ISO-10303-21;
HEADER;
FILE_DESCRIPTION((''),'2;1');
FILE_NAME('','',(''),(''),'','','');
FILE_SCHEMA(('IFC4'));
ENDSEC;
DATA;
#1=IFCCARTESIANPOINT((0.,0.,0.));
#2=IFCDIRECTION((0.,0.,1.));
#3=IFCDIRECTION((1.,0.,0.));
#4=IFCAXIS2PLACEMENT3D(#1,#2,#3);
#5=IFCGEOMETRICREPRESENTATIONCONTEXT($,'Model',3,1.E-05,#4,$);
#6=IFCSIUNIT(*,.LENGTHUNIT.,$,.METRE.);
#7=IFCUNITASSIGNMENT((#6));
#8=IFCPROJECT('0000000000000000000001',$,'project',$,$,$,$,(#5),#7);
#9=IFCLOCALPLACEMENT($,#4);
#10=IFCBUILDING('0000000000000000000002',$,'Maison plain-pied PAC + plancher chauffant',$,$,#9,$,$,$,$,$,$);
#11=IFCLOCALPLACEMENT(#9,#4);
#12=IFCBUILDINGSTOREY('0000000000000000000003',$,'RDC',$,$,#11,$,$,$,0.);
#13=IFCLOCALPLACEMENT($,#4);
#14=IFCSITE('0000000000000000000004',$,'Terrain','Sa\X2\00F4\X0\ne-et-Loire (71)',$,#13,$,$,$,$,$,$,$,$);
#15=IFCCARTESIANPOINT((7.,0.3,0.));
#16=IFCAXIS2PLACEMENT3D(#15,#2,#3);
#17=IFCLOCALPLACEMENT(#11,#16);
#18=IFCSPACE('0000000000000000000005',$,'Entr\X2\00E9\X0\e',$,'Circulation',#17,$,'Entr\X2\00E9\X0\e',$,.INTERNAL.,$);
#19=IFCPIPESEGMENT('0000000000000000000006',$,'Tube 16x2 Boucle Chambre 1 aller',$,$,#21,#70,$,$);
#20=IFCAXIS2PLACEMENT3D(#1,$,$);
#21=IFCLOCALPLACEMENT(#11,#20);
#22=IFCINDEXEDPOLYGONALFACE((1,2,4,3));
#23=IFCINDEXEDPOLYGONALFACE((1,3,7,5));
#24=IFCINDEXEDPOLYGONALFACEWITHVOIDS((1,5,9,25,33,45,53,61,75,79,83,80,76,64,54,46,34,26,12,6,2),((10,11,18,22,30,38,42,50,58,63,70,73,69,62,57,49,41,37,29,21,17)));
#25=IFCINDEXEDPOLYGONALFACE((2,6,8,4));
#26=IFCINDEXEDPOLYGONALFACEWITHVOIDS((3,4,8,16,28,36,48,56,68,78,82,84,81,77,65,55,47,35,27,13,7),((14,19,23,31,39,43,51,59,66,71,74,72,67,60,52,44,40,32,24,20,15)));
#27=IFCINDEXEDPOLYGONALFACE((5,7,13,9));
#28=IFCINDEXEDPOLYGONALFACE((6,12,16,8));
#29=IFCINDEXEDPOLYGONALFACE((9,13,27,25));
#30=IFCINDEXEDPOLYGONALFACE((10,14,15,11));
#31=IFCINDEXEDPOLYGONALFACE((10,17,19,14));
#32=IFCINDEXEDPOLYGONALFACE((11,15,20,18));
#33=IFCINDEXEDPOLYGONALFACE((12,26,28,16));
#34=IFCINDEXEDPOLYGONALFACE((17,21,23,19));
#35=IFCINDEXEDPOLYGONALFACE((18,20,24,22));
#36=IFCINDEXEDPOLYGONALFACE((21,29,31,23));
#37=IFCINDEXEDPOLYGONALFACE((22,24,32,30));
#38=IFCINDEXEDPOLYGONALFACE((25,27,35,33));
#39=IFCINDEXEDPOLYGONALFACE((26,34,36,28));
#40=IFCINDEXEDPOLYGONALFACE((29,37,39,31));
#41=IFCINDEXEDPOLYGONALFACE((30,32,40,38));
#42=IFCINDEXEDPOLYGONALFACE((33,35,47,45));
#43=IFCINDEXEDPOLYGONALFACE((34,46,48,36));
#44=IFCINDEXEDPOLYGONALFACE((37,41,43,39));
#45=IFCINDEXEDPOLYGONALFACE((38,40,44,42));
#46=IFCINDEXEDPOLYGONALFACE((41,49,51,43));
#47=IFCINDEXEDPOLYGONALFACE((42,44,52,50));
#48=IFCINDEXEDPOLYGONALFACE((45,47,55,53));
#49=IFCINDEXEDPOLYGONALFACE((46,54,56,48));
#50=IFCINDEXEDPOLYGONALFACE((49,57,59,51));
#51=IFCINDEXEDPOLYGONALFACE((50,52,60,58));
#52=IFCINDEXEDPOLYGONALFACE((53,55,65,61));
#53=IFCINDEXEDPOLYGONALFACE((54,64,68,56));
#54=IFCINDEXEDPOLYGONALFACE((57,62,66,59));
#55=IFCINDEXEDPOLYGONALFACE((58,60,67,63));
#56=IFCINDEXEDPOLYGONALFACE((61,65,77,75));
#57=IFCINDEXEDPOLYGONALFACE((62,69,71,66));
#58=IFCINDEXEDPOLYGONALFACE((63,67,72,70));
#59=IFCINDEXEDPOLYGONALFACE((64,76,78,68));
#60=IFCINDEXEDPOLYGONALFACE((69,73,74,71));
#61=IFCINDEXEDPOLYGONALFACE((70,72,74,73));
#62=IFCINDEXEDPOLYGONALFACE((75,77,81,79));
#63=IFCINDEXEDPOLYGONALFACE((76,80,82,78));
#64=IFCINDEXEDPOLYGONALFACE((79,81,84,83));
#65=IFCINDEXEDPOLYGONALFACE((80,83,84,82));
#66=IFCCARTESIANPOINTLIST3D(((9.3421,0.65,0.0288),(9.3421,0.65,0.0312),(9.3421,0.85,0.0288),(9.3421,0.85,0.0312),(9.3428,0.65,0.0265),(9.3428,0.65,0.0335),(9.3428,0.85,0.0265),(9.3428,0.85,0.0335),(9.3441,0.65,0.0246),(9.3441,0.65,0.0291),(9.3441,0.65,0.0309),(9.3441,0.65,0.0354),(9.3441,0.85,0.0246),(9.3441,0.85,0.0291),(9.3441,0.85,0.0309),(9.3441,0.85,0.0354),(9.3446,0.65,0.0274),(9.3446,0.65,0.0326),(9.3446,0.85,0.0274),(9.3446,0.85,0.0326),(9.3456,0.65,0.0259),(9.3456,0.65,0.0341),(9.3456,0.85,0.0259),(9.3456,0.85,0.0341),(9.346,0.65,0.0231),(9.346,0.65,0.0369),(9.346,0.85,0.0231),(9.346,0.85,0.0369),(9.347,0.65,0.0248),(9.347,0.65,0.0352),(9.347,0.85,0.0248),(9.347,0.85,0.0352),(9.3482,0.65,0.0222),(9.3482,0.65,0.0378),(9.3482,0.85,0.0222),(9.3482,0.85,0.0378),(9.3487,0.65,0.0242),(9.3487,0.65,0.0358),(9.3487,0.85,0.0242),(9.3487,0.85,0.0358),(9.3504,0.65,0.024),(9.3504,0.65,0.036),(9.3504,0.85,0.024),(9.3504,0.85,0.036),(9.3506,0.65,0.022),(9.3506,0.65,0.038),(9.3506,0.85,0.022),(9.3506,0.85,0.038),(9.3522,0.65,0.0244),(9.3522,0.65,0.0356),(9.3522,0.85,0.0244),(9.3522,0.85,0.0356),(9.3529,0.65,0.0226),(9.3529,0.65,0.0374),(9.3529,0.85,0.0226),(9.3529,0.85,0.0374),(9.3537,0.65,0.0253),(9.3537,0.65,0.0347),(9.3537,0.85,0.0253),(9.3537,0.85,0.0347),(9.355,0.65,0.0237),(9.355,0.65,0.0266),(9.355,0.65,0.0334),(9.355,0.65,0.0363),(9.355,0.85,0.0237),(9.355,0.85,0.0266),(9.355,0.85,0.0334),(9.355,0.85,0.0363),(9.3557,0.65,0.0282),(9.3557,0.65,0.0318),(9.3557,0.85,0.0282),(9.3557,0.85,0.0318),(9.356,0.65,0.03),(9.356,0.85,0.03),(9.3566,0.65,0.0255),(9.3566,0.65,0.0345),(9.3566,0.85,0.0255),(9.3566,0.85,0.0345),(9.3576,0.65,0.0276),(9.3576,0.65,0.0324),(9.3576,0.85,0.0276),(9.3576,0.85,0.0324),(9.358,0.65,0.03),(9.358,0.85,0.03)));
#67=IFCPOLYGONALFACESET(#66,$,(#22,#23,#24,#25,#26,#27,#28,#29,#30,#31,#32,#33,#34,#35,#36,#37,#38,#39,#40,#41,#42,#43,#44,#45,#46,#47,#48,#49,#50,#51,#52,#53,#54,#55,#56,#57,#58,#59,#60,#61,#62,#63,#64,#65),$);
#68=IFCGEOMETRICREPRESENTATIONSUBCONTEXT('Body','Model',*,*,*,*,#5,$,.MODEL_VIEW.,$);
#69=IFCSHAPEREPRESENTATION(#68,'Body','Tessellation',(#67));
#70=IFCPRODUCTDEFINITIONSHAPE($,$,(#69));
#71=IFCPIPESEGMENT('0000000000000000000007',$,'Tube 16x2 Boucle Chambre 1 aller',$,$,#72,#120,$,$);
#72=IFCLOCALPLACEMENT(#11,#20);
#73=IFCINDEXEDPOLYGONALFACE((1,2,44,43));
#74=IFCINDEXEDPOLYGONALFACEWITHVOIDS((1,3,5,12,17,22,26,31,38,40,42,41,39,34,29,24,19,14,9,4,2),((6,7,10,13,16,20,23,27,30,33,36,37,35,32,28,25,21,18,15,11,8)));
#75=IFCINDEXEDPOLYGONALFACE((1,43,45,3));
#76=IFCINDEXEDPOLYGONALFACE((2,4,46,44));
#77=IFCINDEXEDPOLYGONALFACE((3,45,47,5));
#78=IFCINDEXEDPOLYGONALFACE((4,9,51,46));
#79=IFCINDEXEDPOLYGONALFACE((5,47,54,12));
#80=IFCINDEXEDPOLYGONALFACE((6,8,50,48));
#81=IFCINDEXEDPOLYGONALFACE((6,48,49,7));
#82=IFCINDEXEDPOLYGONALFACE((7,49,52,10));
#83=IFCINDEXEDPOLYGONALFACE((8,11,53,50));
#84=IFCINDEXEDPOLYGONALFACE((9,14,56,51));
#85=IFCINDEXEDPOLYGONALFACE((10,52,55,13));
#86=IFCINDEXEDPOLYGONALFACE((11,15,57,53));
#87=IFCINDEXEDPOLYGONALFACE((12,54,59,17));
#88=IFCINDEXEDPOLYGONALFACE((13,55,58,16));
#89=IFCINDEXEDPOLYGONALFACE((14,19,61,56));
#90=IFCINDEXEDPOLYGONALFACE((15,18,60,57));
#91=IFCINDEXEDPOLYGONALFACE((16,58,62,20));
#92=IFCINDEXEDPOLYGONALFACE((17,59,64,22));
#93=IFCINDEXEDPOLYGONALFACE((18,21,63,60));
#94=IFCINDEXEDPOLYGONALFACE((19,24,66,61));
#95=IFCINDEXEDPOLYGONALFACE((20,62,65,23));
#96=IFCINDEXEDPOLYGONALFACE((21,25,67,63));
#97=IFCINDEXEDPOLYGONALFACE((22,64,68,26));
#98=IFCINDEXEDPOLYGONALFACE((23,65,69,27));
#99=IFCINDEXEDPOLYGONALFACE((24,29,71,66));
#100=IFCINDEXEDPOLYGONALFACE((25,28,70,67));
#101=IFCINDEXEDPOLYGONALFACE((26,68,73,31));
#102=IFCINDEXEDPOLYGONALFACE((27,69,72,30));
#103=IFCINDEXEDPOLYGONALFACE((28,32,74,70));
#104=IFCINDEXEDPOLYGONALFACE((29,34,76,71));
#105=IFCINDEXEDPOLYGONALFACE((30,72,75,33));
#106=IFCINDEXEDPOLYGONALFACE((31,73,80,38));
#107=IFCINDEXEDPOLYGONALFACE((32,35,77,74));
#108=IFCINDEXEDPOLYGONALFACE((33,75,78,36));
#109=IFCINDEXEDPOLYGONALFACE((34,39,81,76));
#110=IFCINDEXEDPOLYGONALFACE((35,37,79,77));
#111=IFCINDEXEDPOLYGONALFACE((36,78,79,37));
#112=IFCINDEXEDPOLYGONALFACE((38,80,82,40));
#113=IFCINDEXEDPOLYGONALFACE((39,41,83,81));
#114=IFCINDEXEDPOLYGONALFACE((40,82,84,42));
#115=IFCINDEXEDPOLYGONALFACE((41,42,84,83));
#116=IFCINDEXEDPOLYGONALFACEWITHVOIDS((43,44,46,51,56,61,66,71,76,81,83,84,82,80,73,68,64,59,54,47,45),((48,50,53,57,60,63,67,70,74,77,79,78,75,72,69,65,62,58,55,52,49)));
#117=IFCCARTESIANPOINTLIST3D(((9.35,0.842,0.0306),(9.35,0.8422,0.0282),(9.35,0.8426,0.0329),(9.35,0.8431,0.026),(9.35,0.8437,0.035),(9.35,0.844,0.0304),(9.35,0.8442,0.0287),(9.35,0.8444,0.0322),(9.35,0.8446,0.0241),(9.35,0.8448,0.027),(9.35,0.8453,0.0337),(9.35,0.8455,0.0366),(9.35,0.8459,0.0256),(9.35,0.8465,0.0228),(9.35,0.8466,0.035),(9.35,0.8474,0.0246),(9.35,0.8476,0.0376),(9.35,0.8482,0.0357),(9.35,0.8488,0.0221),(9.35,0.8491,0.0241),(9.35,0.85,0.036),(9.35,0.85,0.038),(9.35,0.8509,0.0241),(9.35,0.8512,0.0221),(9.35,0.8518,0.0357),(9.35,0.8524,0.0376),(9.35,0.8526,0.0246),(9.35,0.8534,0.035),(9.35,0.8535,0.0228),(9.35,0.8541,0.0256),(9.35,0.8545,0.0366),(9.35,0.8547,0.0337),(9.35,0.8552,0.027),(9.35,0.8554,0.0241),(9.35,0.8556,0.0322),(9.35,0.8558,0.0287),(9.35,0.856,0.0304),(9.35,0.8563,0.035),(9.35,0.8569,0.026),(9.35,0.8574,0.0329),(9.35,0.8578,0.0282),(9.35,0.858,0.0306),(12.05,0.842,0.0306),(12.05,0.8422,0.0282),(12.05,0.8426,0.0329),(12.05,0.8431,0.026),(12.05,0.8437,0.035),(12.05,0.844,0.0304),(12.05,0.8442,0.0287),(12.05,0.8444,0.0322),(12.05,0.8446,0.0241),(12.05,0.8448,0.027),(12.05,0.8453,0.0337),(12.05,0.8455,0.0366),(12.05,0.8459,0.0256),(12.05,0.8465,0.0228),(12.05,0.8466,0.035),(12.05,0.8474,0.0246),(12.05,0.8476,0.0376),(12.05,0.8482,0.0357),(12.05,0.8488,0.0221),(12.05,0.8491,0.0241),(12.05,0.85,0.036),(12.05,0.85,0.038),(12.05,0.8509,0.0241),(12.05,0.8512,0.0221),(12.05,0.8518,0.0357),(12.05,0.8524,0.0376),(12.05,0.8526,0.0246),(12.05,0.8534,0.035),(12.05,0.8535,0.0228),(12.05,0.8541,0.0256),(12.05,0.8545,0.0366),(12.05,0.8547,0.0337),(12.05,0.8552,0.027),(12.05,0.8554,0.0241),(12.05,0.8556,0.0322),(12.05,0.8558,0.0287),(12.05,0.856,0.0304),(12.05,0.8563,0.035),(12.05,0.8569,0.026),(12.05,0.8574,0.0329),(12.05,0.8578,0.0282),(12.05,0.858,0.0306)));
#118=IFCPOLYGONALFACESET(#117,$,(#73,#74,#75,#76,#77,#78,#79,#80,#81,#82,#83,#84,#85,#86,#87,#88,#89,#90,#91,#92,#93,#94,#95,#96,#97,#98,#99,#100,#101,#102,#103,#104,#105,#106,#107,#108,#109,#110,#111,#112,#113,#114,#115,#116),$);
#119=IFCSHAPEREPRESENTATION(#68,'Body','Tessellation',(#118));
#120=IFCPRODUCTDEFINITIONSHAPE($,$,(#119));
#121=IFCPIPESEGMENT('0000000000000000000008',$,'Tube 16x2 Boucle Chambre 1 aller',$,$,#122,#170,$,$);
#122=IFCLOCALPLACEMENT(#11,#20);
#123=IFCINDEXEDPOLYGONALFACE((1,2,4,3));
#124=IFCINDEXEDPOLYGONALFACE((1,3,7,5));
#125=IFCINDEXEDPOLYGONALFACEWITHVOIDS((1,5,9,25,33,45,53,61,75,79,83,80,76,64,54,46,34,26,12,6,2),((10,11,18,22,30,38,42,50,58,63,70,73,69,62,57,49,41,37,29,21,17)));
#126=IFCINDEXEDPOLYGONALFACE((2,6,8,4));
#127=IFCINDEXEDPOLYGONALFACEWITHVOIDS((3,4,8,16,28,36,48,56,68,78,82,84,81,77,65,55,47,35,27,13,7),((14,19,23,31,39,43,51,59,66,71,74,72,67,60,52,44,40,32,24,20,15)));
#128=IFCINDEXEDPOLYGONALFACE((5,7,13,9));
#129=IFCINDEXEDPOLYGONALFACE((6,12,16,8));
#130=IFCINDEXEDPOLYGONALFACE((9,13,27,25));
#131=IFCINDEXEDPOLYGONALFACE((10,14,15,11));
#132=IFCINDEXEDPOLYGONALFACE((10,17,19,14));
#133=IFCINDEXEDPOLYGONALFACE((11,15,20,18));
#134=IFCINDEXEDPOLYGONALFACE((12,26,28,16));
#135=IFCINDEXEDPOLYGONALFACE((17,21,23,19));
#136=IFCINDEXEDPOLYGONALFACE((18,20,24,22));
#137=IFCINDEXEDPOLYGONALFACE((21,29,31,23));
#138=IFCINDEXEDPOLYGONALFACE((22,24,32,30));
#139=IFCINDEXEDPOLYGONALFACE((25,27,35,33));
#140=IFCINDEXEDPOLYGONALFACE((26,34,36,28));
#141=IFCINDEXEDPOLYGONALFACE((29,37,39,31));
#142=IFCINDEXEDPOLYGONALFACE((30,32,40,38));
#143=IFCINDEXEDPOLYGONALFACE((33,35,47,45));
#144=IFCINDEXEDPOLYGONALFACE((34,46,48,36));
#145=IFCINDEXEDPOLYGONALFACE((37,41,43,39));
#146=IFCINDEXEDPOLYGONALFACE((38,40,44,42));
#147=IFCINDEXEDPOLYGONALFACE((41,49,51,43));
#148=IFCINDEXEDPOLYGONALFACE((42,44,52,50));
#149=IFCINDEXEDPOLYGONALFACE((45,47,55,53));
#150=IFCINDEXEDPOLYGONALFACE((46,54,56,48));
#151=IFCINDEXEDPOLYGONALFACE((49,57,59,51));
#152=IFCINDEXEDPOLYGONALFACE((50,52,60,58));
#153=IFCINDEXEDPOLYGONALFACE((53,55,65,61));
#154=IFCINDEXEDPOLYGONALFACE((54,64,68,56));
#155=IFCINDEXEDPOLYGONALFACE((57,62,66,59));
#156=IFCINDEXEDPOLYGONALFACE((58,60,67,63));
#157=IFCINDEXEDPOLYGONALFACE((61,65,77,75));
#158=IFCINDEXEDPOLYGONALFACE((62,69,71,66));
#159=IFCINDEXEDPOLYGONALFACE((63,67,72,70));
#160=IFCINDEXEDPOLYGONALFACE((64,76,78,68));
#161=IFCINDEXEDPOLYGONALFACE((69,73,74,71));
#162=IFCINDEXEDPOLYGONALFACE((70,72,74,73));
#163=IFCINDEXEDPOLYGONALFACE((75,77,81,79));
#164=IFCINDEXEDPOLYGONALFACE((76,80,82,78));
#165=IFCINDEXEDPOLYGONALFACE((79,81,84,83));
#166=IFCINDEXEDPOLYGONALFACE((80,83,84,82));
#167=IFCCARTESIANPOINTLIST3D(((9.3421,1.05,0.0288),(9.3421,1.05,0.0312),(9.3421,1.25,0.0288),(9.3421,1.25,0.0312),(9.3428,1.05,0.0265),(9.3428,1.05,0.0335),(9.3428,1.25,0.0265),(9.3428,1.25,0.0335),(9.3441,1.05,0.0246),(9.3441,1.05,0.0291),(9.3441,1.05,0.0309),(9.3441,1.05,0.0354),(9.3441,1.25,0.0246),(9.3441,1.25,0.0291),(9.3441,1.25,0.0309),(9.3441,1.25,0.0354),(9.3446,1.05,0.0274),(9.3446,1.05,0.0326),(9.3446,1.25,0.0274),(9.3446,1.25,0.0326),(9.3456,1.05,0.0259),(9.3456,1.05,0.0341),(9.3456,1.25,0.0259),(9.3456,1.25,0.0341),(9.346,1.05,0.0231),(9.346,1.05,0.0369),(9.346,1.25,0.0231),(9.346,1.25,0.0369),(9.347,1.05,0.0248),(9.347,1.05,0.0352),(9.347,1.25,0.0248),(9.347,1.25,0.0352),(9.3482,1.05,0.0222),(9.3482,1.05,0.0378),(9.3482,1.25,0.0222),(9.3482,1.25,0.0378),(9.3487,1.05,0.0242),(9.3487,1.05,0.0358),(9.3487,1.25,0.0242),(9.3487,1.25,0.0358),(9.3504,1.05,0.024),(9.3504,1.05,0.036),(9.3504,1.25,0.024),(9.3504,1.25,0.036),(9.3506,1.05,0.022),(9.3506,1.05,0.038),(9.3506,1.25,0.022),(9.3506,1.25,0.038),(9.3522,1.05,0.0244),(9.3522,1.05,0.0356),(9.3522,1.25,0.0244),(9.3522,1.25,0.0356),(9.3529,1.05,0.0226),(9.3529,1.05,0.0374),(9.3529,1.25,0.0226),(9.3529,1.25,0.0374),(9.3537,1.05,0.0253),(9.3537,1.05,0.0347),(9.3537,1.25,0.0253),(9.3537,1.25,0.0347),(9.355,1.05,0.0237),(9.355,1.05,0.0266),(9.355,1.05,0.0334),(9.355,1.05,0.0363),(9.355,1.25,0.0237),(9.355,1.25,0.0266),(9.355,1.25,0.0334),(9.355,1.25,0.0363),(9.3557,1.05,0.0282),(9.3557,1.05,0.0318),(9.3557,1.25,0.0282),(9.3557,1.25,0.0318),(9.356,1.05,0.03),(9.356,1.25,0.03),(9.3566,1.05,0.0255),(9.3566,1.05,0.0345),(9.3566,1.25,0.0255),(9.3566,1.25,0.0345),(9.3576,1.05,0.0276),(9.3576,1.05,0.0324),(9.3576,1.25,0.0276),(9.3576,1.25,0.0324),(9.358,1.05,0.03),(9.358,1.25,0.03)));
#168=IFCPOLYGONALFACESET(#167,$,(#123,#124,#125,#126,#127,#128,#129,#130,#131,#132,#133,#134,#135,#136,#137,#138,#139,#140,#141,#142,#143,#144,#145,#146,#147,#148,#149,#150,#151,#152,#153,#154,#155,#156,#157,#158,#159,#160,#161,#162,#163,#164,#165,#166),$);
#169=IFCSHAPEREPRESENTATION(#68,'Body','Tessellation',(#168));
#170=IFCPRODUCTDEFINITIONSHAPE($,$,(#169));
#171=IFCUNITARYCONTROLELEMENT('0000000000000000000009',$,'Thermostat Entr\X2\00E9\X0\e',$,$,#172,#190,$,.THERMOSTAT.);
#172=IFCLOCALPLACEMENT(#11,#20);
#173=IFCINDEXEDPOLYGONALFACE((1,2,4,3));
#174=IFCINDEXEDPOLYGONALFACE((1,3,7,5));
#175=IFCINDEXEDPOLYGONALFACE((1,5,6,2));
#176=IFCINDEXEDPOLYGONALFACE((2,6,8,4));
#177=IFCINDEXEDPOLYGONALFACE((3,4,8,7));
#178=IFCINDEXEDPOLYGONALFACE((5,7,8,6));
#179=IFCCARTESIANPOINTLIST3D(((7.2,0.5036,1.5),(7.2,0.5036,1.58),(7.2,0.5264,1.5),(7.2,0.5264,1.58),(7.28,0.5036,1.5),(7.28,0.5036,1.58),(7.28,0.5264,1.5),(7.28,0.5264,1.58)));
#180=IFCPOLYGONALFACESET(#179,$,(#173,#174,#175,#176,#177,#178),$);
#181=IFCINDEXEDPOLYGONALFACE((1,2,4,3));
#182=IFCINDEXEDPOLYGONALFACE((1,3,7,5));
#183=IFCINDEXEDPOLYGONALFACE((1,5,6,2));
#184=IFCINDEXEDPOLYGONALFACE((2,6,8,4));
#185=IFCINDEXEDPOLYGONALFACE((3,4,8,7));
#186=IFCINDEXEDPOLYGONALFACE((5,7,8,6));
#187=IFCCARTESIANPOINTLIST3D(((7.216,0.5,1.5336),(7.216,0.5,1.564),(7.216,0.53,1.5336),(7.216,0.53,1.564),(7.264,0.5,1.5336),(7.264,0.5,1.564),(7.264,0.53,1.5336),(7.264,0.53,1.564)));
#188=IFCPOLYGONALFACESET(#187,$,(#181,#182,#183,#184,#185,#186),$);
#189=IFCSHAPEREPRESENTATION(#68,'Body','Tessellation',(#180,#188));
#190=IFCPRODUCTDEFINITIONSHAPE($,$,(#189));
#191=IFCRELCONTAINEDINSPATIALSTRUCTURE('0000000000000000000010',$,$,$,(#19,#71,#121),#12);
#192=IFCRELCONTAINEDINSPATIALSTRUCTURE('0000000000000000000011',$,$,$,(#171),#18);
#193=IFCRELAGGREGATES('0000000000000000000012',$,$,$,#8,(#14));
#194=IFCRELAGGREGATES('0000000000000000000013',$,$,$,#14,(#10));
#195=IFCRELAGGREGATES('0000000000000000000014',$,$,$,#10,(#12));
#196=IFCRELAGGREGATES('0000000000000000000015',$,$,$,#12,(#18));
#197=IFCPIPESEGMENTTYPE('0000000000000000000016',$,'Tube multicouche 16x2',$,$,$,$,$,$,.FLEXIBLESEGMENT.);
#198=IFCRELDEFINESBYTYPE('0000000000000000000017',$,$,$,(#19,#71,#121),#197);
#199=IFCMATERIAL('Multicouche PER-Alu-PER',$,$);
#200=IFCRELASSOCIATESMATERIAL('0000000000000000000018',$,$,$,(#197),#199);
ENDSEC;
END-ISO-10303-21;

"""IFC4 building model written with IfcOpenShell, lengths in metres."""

from ifc_helpers import new_model, si_unit, frame, frame_2d, origin_with_axes, place, context, subcontext, project, spatial, rectangle, hollow_circle, extrude, material, type_object, element, save


model = new_model("IFC4")

# Units and contexts
model_context = context("Model", 3, precision=1e-05, world=origin_with_axes())
body_context = subcontext(model_context, "Body", "Model", "MODEL_VIEW")
ifc_project = project(units=[si_unit("LENGTHUNIT", "METRE")], contexts=[model_context])

# Site, building, storey
site_placement = place(None, origin_with_axes())
site = spatial("IfcSite", under=ifc_project, at=site_placement, Name="Terrain", Description="Saône-et-Loire (71)")
building_placement = place(None, origin_with_axes())
building = spatial("IfcBuilding", under=site, at=building_placement, Name="Maison plain-pied PAC + plancher chauffant")
storey_placement = place(building_placement, origin_with_axes())
storey = spatial("IfcBuildingStorey", under=building, at=storey_placement, Name="RDC", Elevation=0.0)

# Pipe segments
ifc_material_1 = material(Name="Multicouche PER-Alu-PER")
pipe_segment_type = type_object("IfcPipeSegmentType", Name="Tube multicouche 16x2", PredefinedType="FLEXIBLESEGMENT", material=ifc_material_1)
pipe_segment_1_placement = place(storey_placement, frame((9.35, 0.65, 0.03), z_axis=(0.0, 1.0, 0.0), x_axis=(1.0, 0.0, 0.0)))
element("IfcPipeSegment", 1, at=pipe_segment_1_placement, inside=storey, type_object=pipe_segment_type, Name="Tube 16x2 Boucle Chambre 1 aller", context=body_context, shape_type="SweptSolid", body=[
    extrude(hollow_circle(Radius=0.008, WallThickness=0.002), origin_with_axes(), (0.0, 0.0, 1.0), 0.2),
])
pipe_segment_2_placement = place(storey_placement, frame((9.35, 0.85, 0.03), z_axis=(1.0, 0.0, 0.0), x_axis=(0.0, 0.0, 1.0)))
element("IfcPipeSegment", 2, at=pipe_segment_2_placement, inside=storey, type_object=pipe_segment_type, Name="Tube 16x2 Boucle Chambre 1 aller", context=body_context, shape_type="SweptSolid", body=[
    extrude(hollow_circle(Radius=0.008, WallThickness=0.002), origin_with_axes(), (0.0, 0.0, 1.0), 2.7),
])
pipe_segment_3_placement = place(storey_placement, frame((9.35, 1.05, 0.03), z_axis=(0.0, 1.0, 0.0), x_axis=(1.0, 0.0, 0.0)))
element("IfcPipeSegment", 3, at=pipe_segment_3_placement, inside=storey, type_object=pipe_segment_type, Name="Tube 16x2 Boucle Chambre 1 aller", context=body_context, shape_type="SweptSolid", body=[
    extrude(hollow_circle(Radius=0.008, WallThickness=0.002), origin_with_axes(), (0.0, 0.0, 1.0), 0.2),
])

# Shared definitions
space_1_placement = place(storey_placement, frame((7.0, 0.3, 0.0), z_axis=(0.0, 0.0, 1.0), x_axis=(1.0, 0.0, 0.0)))
space_1 = spatial("IfcSpace", under=storey, at=space_1_placement, Name="Entrée", ObjectType="Circulation", LongName="Entrée", PredefinedType="INTERNAL")

# Unitary control element
unitary_control_element_placement = place(space_1_placement, frame((0.2, 0.2, 1.5), z_axis=(0.0, 0.0, 1.0), x_axis=(1.0, 0.0, 0.0)))
element("IfcUnitaryControlElement", 4, at=unitary_control_element_placement, inside=space_1, Name="Thermostat Entrée", PredefinedType="THERMOSTAT", context=body_context, shape_type="SweptSolid", body=[
    extrude(rectangle(XDim=0.08, YDim=0.0228, at=frame_2d((0.04, 0.0114))), frame((0.0, 0.0036, 0.0), z_axis=(0.0, 0.0, 1.0), x_axis=(1.0, 0.0, 0.0)), (0.0, 0.0, 1.0), 0.08),
    extrude(rectangle(XDim=0.048, YDim=0.03, at=frame_2d((0.024, 0.015))), frame((0.016, 0.0, 0.0336), z_axis=(0.0, 0.0, 1.0), x_axis=(1.0, 0.0, 0.0)), (0.0, 0.0, 1.0), 0.0304),
])

save(model, "model.ifc")
